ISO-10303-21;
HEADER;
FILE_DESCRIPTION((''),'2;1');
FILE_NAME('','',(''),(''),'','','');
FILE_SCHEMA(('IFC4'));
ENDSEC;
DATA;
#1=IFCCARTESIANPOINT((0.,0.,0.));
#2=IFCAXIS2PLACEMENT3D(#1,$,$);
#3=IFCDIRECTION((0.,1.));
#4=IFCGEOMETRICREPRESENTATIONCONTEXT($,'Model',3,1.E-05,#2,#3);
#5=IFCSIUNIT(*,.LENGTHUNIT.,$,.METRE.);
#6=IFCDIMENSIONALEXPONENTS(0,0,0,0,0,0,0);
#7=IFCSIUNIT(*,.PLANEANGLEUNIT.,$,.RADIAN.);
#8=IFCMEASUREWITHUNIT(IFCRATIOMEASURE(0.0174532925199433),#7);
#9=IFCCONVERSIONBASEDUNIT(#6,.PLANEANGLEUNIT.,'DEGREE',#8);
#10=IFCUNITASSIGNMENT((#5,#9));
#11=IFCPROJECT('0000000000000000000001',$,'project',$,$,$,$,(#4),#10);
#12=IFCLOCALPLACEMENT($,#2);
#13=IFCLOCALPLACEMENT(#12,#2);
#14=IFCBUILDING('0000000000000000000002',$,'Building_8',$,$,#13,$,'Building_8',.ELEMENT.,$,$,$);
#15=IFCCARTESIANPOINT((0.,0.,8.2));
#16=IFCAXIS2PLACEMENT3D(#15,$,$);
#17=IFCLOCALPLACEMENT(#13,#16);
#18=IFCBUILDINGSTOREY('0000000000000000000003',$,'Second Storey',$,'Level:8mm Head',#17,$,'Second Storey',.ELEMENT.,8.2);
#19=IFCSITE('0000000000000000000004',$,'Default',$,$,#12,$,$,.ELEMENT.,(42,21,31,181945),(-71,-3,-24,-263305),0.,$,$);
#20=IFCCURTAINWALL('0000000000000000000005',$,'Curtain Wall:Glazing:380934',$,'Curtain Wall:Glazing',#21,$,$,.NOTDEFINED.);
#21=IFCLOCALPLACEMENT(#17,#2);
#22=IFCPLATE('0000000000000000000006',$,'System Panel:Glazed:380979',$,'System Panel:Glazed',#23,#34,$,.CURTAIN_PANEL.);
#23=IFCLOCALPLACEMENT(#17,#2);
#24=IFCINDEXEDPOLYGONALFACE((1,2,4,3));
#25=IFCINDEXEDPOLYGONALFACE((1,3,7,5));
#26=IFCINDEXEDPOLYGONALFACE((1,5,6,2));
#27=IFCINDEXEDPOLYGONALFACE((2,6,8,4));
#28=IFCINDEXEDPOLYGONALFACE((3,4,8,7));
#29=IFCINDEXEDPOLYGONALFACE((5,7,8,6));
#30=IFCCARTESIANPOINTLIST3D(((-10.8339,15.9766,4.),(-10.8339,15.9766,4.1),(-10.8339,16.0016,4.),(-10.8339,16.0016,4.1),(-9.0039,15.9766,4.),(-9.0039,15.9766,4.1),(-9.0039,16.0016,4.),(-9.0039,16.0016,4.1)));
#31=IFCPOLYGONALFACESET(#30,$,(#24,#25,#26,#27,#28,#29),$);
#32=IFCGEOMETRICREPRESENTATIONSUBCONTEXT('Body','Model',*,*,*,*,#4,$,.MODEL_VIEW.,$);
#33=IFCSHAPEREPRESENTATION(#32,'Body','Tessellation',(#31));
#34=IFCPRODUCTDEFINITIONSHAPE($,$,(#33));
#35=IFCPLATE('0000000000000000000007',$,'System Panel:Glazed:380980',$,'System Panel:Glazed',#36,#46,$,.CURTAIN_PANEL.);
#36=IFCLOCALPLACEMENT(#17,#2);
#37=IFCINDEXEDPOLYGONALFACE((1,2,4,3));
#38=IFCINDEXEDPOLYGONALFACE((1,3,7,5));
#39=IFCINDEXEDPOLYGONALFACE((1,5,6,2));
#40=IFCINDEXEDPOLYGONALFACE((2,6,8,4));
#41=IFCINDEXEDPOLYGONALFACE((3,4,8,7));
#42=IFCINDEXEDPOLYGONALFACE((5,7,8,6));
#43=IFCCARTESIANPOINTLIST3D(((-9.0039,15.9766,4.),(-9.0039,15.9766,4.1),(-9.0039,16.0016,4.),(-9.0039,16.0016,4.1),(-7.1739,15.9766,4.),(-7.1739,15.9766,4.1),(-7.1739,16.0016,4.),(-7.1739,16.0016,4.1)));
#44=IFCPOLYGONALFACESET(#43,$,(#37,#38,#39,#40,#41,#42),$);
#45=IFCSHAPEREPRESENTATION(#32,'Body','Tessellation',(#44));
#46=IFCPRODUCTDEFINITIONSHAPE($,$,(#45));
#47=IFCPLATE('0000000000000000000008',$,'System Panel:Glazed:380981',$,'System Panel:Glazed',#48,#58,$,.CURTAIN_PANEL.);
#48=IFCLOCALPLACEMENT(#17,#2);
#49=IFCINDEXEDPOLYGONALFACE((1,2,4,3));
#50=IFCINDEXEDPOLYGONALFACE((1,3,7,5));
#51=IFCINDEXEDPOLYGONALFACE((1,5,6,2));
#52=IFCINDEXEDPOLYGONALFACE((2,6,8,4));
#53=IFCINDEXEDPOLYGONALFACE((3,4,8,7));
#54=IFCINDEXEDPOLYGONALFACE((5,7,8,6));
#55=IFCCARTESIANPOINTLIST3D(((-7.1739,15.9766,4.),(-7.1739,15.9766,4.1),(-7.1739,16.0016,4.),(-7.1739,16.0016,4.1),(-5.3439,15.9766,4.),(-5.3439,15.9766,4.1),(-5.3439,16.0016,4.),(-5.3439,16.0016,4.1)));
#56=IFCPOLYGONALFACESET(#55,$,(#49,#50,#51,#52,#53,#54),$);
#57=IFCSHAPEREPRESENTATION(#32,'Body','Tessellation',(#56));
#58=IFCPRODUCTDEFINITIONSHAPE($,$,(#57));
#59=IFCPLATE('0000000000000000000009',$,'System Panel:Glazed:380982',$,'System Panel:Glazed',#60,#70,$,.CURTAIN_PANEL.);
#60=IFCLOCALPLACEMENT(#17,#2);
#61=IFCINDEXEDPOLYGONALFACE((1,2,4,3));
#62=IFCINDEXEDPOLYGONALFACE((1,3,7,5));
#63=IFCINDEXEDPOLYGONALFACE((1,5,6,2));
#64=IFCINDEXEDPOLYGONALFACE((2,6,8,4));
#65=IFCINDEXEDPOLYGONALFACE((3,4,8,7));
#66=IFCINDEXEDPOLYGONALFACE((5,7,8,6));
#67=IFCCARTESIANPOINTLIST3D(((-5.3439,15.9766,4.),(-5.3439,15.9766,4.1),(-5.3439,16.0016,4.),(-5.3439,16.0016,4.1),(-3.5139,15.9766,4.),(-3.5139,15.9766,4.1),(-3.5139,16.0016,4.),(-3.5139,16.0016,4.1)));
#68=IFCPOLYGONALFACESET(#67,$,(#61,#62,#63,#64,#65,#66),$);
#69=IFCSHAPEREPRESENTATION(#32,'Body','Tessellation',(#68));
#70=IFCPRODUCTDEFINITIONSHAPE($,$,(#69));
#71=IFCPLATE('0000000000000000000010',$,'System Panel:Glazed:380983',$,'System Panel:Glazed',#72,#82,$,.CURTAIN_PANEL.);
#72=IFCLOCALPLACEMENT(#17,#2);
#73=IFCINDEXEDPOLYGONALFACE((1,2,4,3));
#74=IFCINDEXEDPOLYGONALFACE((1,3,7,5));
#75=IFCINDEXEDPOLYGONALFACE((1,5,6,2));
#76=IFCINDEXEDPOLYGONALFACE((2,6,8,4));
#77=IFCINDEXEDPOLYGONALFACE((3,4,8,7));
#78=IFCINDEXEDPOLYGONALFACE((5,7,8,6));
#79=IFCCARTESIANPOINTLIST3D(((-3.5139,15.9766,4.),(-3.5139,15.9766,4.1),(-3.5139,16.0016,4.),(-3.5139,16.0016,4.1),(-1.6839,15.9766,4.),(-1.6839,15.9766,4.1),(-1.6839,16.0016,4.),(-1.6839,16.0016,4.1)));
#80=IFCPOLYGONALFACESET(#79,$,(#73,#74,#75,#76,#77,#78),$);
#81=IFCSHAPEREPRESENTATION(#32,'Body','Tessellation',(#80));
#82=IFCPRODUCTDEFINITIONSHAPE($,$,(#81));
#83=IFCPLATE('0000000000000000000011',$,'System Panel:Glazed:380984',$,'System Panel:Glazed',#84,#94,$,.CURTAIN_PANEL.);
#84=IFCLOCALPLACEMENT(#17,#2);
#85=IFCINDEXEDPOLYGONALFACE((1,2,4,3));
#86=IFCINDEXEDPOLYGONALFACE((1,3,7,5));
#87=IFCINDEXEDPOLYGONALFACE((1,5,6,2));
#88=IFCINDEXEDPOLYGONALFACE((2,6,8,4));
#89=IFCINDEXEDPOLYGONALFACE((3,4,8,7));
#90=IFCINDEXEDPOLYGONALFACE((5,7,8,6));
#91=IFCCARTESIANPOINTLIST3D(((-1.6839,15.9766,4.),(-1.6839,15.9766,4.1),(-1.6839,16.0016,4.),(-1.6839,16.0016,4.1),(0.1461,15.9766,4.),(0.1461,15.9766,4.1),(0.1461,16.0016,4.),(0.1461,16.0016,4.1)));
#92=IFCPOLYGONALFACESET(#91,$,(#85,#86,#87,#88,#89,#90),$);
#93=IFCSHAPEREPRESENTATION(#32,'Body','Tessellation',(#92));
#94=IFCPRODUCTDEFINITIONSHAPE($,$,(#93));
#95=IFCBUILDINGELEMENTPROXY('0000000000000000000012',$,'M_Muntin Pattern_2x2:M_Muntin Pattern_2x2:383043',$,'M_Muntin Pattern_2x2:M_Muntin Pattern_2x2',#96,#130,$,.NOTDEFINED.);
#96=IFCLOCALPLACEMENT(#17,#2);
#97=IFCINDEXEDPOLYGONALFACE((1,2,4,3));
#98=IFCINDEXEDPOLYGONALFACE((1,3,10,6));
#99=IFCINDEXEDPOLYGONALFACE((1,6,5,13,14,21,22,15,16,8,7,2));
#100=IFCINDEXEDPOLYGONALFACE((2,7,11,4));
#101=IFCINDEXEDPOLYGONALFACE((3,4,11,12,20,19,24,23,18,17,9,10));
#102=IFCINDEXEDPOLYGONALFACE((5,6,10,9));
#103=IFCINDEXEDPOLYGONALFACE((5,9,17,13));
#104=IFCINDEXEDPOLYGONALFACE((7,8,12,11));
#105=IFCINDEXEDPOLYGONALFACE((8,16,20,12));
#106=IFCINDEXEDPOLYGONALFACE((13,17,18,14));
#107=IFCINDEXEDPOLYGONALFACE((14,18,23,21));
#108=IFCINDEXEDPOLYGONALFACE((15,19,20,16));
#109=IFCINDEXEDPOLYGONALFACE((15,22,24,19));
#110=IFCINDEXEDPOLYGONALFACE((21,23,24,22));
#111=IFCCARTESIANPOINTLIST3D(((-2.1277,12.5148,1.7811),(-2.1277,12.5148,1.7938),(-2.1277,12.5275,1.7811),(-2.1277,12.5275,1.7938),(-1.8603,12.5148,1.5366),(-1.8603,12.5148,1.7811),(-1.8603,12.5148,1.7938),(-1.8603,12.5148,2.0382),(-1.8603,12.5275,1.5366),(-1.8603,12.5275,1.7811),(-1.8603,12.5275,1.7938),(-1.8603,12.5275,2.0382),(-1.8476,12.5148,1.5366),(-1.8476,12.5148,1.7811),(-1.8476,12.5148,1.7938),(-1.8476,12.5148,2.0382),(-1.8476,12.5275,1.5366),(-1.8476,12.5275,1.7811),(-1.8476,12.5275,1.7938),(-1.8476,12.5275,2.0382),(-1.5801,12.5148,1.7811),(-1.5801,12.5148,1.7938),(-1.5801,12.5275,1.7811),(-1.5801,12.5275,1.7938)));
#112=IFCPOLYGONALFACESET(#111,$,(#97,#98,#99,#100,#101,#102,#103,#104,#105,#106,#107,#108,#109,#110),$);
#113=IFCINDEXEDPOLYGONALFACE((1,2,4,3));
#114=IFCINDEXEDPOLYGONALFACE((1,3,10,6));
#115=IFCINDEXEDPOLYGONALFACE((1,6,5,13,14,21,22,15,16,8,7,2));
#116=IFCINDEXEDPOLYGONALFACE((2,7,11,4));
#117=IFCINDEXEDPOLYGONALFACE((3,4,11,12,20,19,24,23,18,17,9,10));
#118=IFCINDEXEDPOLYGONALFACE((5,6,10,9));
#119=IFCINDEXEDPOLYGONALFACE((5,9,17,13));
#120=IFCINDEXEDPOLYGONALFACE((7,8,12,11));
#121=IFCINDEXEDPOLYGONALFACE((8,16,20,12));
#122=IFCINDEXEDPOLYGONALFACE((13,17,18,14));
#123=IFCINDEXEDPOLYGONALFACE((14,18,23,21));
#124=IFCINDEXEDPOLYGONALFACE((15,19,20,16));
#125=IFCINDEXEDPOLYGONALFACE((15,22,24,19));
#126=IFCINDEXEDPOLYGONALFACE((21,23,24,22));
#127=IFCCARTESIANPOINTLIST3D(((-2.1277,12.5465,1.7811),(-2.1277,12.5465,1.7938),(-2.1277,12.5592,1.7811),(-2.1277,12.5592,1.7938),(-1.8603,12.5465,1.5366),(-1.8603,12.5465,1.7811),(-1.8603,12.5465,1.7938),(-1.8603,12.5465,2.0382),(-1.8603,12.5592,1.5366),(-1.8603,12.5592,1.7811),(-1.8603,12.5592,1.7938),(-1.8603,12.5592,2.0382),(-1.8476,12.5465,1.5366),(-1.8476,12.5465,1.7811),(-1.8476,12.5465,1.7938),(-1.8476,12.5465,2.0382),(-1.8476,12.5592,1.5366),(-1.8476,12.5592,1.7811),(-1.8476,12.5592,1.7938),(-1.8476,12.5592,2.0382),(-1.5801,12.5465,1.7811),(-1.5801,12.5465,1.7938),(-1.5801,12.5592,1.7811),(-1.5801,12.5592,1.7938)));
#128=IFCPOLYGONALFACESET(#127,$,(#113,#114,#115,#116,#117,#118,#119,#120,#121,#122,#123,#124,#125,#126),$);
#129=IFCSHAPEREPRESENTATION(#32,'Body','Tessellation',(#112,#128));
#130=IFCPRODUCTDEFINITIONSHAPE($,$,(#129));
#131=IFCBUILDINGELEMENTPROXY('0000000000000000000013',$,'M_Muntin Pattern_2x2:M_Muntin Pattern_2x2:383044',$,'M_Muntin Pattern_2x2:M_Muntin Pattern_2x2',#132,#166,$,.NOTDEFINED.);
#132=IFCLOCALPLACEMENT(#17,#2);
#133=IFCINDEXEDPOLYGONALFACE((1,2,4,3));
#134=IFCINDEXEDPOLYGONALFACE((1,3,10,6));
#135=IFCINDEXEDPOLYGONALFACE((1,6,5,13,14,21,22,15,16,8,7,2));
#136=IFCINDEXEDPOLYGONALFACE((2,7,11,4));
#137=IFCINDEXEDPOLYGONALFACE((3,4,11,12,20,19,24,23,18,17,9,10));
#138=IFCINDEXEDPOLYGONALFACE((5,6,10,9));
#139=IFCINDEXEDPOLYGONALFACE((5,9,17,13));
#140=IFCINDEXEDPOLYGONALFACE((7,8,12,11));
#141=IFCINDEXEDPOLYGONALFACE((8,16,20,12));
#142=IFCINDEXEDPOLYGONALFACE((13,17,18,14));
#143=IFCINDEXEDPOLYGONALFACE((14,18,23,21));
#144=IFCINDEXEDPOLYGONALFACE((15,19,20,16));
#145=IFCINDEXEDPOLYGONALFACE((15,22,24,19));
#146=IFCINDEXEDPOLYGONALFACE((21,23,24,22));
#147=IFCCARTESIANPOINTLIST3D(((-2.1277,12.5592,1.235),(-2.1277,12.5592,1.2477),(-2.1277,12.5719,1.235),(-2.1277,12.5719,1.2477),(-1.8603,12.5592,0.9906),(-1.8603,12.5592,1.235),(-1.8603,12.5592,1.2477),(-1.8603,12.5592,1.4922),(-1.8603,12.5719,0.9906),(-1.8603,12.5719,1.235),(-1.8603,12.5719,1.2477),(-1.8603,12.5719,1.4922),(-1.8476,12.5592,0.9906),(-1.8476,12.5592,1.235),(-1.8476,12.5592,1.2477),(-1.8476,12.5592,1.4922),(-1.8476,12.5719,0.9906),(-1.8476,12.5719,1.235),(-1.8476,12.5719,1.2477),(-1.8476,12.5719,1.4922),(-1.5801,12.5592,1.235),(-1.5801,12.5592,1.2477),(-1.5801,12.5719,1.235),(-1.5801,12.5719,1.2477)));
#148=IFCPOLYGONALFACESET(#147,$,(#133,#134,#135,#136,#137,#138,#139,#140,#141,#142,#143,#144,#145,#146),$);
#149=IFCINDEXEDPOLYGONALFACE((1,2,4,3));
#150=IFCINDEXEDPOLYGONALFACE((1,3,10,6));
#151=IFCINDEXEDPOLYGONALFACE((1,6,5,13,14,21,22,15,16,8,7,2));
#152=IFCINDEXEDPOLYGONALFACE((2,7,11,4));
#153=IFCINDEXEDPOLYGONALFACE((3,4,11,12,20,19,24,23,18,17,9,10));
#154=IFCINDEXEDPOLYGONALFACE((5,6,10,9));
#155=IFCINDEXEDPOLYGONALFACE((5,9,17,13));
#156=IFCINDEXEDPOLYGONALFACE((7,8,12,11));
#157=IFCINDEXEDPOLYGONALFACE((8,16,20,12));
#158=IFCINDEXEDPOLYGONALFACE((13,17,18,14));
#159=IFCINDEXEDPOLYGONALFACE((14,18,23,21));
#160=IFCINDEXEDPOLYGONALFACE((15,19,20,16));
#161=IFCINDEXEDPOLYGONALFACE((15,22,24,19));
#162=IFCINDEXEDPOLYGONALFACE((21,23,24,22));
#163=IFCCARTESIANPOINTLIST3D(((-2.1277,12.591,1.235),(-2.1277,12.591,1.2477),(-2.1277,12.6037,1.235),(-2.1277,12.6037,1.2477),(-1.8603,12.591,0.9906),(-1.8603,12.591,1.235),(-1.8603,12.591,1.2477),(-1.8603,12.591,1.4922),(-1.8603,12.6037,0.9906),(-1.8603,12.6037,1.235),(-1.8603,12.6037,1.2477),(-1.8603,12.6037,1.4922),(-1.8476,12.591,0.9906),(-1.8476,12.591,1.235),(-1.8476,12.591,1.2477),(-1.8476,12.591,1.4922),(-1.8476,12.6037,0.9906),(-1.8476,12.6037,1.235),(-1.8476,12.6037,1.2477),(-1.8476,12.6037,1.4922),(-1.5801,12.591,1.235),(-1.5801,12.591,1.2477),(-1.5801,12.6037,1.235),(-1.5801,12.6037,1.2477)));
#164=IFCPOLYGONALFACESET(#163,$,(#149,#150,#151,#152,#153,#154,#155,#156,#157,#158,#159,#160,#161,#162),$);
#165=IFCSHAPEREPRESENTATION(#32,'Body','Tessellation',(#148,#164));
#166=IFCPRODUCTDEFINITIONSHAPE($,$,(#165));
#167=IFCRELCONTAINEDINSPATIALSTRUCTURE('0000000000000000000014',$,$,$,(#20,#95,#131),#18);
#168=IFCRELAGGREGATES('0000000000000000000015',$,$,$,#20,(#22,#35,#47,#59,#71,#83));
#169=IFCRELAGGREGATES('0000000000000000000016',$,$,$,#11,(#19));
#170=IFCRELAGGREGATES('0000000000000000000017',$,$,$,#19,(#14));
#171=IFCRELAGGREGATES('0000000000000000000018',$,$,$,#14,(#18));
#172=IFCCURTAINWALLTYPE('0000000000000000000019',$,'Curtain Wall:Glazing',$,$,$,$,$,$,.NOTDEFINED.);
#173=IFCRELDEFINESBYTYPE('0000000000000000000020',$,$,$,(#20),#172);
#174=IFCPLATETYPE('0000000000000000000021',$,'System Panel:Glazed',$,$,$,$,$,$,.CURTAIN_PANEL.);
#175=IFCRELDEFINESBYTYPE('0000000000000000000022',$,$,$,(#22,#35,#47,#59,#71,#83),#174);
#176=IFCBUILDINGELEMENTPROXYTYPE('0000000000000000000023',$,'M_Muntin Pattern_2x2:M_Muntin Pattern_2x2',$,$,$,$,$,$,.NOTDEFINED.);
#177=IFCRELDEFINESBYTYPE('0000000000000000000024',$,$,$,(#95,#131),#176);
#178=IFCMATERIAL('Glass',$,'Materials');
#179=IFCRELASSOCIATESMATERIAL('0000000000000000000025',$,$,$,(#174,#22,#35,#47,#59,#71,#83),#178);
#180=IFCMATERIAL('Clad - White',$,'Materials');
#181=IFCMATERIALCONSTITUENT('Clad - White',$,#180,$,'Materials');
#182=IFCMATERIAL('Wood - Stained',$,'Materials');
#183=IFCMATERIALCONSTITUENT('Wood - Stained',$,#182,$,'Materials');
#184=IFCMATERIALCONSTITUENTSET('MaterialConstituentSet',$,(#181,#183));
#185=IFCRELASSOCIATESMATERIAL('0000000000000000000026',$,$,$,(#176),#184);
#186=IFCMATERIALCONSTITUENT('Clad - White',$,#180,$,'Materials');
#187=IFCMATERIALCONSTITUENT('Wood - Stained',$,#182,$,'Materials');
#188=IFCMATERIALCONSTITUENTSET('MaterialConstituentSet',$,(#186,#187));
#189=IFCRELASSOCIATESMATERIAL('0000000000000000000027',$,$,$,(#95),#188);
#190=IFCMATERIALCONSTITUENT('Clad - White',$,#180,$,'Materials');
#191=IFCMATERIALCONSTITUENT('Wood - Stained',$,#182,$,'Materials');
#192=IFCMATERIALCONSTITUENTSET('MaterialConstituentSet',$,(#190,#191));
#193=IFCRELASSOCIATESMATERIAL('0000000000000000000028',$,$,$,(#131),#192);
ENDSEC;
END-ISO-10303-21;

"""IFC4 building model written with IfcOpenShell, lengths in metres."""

from ifc_helpers import new_model, entity, si_unit, converted_unit, direction, frame, origin, place, context, subcontext, project, spatial, indexed_curve, outline, extrude, source, transform, mapped, material, constituent, constituent_set, type_object, type_shapes, element, aggregate, save


model = new_model("IFC4")

# Units and contexts
model_context = context("Model", 3, precision=1e-05, world=origin(), true_north=direction((0.0, 1.0)))
body_context = subcontext(model_context, "Body", "Model", "MODEL_VIEW")
ifc_project = project(units=[si_unit("LENGTHUNIT", "METRE"), converted_unit("PLANEANGLEUNIT", "DEGREE", entity("IfcRatioMeasure", 0.0174532925199433), si_unit("PLANEANGLEUNIT", "RADIAN"), dimensions=[0, 0, 0, 0, 0, 0, 0])], contexts=[model_context])

# Site, building, storey
site_placement = place(None, origin())
site = spatial("IfcSite", under=ifc_project, at=site_placement, Name="Default", CompositionType="ELEMENT", RefLatitude=(42, 21, 31, 181945), RefLongitude=(-71, -3, -24, -263305), RefElevation=0.0)
building_placement = place(site_placement, origin())
building = spatial("IfcBuilding", under=site, at=building_placement, Name="Building_8", LongName="Building_8", CompositionType="ELEMENT")
storey_placement = place(building_placement, frame((0.0, 0.0, 8.2)))
storey = spatial("IfcBuildingStorey", under=building, at=storey_placement, Name="Second Storey", ObjectType="Level:8mm Head", LongName="Second Storey", CompositionType="ELEMENT", Elevation=8.2)

# Curtain wall, plates
curtain_wall_type = type_object("IfcCurtainWallType", Name="Curtain Wall:Glazing", PredefinedType="NOTDEFINED")
curtain_wall_placement = place(storey_placement, frame((0.0, 0.0, -8.2)))
curtain_wall = element("IfcCurtainWall", 1, at=curtain_wall_placement, inside=storey, type_object=curtain_wall_type, Name="Curtain Wall:Glazing:380934", ObjectType="Curtain Wall:Glazing", PredefinedType="NOTDEFINED")
ifc_material_1 = material(Name="Glass", Category="Materials")
plate_type_1 = type_object("IfcPlateType", Name="System Panel:Glazed", PredefinedType="CURTAIN_PANEL", material=ifc_material_1)
shared_shape_1 = source(origin(), body_context, "Body", "SweptSolid", [
    extrude(outline(indexed_curve([(-0.0125, -0.915), (0.0125, -0.915), (0.0125, 0.915), (-0.0125, 0.915), (-0.0125, -0.915)], self_intersect=False)), frame((0.0, 0.037, 0.0), z_axis=(0.0, 0.0, 1.0), x_axis=(0.0, 1.0, 0.0)), (0.0, 0.0, 1.0), 0.1),
])
type_shapes(plate_type_1, [shared_shape_1])
plate_1_placement = place(curtain_wall_placement, frame((-9.9189, 15.9521, 12.2)))
plate_1 = element("IfcPlate", 2, at=plate_1_placement, type_object=plate_type_1, material=ifc_material_1, Name="System Panel:Glazed:380979", ObjectType="System Panel:Glazed", PredefinedType="CURTAIN_PANEL", context=body_context, shape_type="MappedRepresentation", body=[
    mapped(shared_shape_1, transform((0.0, 0.0, 0.0), scale=1.0)),
])
plate_2_placement = place(curtain_wall_placement, frame((-8.0889, 15.9521, 12.2)))
plate_2 = element("IfcPlate", 3, at=plate_2_placement, type_object=plate_type_1, material=ifc_material_1, Name="System Panel:Glazed:380980", ObjectType="System Panel:Glazed", PredefinedType="CURTAIN_PANEL", context=body_context, shape_type="MappedRepresentation", body=[
    mapped(shared_shape_1, transform((0.0, 0.0, 0.0), scale=1.0)),
])
plate_3_placement = place(curtain_wall_placement, frame((-6.2589, 15.9521, 12.2)))
plate_3 = element("IfcPlate", 4, at=plate_3_placement, type_object=plate_type_1, material=ifc_material_1, Name="System Panel:Glazed:380981", ObjectType="System Panel:Glazed", PredefinedType="CURTAIN_PANEL", context=body_context, shape_type="MappedRepresentation", body=[
    mapped(shared_shape_1, transform((0.0, 0.0, 0.0), scale=1.0)),
])
plate_4_placement = place(curtain_wall_placement, frame((-4.4289, 15.9521, 12.2)))
plate_4 = element("IfcPlate", 5, at=plate_4_placement, type_object=plate_type_1, material=ifc_material_1, Name="System Panel:Glazed:380982", ObjectType="System Panel:Glazed", PredefinedType="CURTAIN_PANEL", context=body_context, shape_type="MappedRepresentation", body=[
    mapped(shared_shape_1, transform((0.0, 0.0, 0.0), scale=1.0)),
])
plate_5_placement = place(curtain_wall_placement, frame((-2.5989, 15.9521, 12.2)))
plate_5 = element("IfcPlate", 6, at=plate_5_placement, type_object=plate_type_1, material=ifc_material_1, Name="System Panel:Glazed:380983", ObjectType="System Panel:Glazed", PredefinedType="CURTAIN_PANEL", context=body_context, shape_type="MappedRepresentation", body=[
    mapped(shared_shape_1, transform((0.0, 0.0, 0.0), scale=1.0)),
])
plate_6_placement = place(curtain_wall_placement, frame((-0.7689, 15.9521, 12.2)))
plate_6 = element("IfcPlate", 7, at=plate_6_placement, type_object=plate_type_1, material=ifc_material_1, Name="System Panel:Glazed:380984", ObjectType="System Panel:Glazed", PredefinedType="CURTAIN_PANEL", context=body_context, shape_type="MappedRepresentation", body=[
    mapped(shared_shape_1, transform((0.0, 0.0, 0.0), scale=1.0)),
])
aggregate(curtain_wall, [plate_1, plate_2, plate_3, plate_4, plate_5, plate_6])

# Building element proxies
ifc_material_2 = material(Name="Clad - White", Category="Materials")
ifc_constituent_1 = constituent(ifc_material_2, Name="Clad - White", Category="Materials")
ifc_material_3 = material(Name="Wood - Stained", Category="Materials")
ifc_constituent_2 = constituent(ifc_material_3, Name="Wood - Stained", Category="Materials")
ifc_constituent_set_1 = constituent_set(constituents=[ifc_constituent_1, ifc_constituent_2], Name="MaterialConstituentSet")
ifc_constituent_3 = constituent(ifc_material_2, Name="Clad - White", Category="Materials")
ifc_constituent_4 = constituent(ifc_material_3, Name="Wood - Stained", Category="Materials")
ifc_constituent_set_2 = constituent_set(constituents=[ifc_constituent_3, ifc_constituent_4], Name="MaterialConstituentSet")
building_element_proxy_type_1 = type_object("IfcBuildingElementProxyType", Name="M_Muntin Pattern_2x2:M_Muntin Pattern_2x2", PredefinedType="NOTDEFINED", material=ifc_constituent_set_2)
shared_shape_2 = source(origin(), body_context, "Body", "SweptSolid", [
    extrude(outline(indexed_curve([(0.0064, -0.0064), (0.2508, -0.0064), (0.2508, 0.0063), (0.0064, 0.0063), (0.0064, 0.2738), (-0.0063, 0.2738), (-0.0063, 0.0063), (-0.2508, 0.0063), (-0.2508, -0.0064), (-0.0063, -0.0064), (-0.0063, -0.2738), (0.0064, -0.2738), (0.0064, -0.0064)], self_intersect=False)), frame((0.0, -0.0222, 0.2508), z_axis=(0.0, 1.0, 0.0), x_axis=(0.0, 0.0, 1.0)), (0.0, 0.0, 1.0), 0.0127),
    extrude(outline(indexed_curve([(0.0064, -0.0064), (0.2508, -0.0064), (0.2508, 0.0063), (0.0064, 0.0063), (0.0064, 0.2738), (-0.0063, 0.2738), (-0.0063, 0.0063), (-0.2508, 0.0063), (-0.2508, -0.0064), (-0.0063, -0.0064), (-0.0063, -0.2738), (0.0064, -0.2738), (0.0064, -0.0064)], self_intersect=False)), frame((0.0, 0.0095, 0.2508), z_axis=(0.0, 1.0, 0.0), x_axis=(0.0, 0.0, 1.0)), (0.0, 0.0, 1.0), 0.0127),
])
type_shapes(building_element_proxy_type_1, [shared_shape_2])
proxy_1_placement = place(storey_placement, frame((-1.8539, 12.537, 1.5366)))
element("IfcBuildingElementProxy", 8, at=proxy_1_placement, inside=storey, type_object=building_element_proxy_type_1, material=ifc_constituent_set_1, Name="M_Muntin Pattern_2x2:M_Muntin Pattern_2x2:383043", ObjectType="M_Muntin Pattern_2x2:M_Muntin Pattern_2x2", PredefinedType="NOTDEFINED", context=body_context, shape_type="MappedRepresentation", body=[
    mapped(shared_shape_2, transform((0.0, 0.0, 0.0), scale=1.0)),
])
ifc_constituent_5 = constituent(ifc_material_2, Name="Clad - White", Category="Materials")
ifc_constituent_6 = constituent(ifc_material_3, Name="Wood - Stained", Category="Materials")
ifc_constituent_set_3 = constituent_set(constituents=[ifc_constituent_5, ifc_constituent_6], Name="MaterialConstituentSet")
proxy_2_placement = place(storey_placement, frame((-1.8539, 12.5814, 0.9906)))
element("IfcBuildingElementProxy", 9, at=proxy_2_placement, inside=storey, type_object=building_element_proxy_type_1, material=ifc_constituent_set_3, Name="M_Muntin Pattern_2x2:M_Muntin Pattern_2x2:383044", ObjectType="M_Muntin Pattern_2x2:M_Muntin Pattern_2x2", PredefinedType="NOTDEFINED", context=body_context, shape_type="MappedRepresentation", body=[
    mapped(shared_shape_2, transform((0.0, 0.0, 0.0), scale=1.0)),
])

save(model, "model.ifc")
